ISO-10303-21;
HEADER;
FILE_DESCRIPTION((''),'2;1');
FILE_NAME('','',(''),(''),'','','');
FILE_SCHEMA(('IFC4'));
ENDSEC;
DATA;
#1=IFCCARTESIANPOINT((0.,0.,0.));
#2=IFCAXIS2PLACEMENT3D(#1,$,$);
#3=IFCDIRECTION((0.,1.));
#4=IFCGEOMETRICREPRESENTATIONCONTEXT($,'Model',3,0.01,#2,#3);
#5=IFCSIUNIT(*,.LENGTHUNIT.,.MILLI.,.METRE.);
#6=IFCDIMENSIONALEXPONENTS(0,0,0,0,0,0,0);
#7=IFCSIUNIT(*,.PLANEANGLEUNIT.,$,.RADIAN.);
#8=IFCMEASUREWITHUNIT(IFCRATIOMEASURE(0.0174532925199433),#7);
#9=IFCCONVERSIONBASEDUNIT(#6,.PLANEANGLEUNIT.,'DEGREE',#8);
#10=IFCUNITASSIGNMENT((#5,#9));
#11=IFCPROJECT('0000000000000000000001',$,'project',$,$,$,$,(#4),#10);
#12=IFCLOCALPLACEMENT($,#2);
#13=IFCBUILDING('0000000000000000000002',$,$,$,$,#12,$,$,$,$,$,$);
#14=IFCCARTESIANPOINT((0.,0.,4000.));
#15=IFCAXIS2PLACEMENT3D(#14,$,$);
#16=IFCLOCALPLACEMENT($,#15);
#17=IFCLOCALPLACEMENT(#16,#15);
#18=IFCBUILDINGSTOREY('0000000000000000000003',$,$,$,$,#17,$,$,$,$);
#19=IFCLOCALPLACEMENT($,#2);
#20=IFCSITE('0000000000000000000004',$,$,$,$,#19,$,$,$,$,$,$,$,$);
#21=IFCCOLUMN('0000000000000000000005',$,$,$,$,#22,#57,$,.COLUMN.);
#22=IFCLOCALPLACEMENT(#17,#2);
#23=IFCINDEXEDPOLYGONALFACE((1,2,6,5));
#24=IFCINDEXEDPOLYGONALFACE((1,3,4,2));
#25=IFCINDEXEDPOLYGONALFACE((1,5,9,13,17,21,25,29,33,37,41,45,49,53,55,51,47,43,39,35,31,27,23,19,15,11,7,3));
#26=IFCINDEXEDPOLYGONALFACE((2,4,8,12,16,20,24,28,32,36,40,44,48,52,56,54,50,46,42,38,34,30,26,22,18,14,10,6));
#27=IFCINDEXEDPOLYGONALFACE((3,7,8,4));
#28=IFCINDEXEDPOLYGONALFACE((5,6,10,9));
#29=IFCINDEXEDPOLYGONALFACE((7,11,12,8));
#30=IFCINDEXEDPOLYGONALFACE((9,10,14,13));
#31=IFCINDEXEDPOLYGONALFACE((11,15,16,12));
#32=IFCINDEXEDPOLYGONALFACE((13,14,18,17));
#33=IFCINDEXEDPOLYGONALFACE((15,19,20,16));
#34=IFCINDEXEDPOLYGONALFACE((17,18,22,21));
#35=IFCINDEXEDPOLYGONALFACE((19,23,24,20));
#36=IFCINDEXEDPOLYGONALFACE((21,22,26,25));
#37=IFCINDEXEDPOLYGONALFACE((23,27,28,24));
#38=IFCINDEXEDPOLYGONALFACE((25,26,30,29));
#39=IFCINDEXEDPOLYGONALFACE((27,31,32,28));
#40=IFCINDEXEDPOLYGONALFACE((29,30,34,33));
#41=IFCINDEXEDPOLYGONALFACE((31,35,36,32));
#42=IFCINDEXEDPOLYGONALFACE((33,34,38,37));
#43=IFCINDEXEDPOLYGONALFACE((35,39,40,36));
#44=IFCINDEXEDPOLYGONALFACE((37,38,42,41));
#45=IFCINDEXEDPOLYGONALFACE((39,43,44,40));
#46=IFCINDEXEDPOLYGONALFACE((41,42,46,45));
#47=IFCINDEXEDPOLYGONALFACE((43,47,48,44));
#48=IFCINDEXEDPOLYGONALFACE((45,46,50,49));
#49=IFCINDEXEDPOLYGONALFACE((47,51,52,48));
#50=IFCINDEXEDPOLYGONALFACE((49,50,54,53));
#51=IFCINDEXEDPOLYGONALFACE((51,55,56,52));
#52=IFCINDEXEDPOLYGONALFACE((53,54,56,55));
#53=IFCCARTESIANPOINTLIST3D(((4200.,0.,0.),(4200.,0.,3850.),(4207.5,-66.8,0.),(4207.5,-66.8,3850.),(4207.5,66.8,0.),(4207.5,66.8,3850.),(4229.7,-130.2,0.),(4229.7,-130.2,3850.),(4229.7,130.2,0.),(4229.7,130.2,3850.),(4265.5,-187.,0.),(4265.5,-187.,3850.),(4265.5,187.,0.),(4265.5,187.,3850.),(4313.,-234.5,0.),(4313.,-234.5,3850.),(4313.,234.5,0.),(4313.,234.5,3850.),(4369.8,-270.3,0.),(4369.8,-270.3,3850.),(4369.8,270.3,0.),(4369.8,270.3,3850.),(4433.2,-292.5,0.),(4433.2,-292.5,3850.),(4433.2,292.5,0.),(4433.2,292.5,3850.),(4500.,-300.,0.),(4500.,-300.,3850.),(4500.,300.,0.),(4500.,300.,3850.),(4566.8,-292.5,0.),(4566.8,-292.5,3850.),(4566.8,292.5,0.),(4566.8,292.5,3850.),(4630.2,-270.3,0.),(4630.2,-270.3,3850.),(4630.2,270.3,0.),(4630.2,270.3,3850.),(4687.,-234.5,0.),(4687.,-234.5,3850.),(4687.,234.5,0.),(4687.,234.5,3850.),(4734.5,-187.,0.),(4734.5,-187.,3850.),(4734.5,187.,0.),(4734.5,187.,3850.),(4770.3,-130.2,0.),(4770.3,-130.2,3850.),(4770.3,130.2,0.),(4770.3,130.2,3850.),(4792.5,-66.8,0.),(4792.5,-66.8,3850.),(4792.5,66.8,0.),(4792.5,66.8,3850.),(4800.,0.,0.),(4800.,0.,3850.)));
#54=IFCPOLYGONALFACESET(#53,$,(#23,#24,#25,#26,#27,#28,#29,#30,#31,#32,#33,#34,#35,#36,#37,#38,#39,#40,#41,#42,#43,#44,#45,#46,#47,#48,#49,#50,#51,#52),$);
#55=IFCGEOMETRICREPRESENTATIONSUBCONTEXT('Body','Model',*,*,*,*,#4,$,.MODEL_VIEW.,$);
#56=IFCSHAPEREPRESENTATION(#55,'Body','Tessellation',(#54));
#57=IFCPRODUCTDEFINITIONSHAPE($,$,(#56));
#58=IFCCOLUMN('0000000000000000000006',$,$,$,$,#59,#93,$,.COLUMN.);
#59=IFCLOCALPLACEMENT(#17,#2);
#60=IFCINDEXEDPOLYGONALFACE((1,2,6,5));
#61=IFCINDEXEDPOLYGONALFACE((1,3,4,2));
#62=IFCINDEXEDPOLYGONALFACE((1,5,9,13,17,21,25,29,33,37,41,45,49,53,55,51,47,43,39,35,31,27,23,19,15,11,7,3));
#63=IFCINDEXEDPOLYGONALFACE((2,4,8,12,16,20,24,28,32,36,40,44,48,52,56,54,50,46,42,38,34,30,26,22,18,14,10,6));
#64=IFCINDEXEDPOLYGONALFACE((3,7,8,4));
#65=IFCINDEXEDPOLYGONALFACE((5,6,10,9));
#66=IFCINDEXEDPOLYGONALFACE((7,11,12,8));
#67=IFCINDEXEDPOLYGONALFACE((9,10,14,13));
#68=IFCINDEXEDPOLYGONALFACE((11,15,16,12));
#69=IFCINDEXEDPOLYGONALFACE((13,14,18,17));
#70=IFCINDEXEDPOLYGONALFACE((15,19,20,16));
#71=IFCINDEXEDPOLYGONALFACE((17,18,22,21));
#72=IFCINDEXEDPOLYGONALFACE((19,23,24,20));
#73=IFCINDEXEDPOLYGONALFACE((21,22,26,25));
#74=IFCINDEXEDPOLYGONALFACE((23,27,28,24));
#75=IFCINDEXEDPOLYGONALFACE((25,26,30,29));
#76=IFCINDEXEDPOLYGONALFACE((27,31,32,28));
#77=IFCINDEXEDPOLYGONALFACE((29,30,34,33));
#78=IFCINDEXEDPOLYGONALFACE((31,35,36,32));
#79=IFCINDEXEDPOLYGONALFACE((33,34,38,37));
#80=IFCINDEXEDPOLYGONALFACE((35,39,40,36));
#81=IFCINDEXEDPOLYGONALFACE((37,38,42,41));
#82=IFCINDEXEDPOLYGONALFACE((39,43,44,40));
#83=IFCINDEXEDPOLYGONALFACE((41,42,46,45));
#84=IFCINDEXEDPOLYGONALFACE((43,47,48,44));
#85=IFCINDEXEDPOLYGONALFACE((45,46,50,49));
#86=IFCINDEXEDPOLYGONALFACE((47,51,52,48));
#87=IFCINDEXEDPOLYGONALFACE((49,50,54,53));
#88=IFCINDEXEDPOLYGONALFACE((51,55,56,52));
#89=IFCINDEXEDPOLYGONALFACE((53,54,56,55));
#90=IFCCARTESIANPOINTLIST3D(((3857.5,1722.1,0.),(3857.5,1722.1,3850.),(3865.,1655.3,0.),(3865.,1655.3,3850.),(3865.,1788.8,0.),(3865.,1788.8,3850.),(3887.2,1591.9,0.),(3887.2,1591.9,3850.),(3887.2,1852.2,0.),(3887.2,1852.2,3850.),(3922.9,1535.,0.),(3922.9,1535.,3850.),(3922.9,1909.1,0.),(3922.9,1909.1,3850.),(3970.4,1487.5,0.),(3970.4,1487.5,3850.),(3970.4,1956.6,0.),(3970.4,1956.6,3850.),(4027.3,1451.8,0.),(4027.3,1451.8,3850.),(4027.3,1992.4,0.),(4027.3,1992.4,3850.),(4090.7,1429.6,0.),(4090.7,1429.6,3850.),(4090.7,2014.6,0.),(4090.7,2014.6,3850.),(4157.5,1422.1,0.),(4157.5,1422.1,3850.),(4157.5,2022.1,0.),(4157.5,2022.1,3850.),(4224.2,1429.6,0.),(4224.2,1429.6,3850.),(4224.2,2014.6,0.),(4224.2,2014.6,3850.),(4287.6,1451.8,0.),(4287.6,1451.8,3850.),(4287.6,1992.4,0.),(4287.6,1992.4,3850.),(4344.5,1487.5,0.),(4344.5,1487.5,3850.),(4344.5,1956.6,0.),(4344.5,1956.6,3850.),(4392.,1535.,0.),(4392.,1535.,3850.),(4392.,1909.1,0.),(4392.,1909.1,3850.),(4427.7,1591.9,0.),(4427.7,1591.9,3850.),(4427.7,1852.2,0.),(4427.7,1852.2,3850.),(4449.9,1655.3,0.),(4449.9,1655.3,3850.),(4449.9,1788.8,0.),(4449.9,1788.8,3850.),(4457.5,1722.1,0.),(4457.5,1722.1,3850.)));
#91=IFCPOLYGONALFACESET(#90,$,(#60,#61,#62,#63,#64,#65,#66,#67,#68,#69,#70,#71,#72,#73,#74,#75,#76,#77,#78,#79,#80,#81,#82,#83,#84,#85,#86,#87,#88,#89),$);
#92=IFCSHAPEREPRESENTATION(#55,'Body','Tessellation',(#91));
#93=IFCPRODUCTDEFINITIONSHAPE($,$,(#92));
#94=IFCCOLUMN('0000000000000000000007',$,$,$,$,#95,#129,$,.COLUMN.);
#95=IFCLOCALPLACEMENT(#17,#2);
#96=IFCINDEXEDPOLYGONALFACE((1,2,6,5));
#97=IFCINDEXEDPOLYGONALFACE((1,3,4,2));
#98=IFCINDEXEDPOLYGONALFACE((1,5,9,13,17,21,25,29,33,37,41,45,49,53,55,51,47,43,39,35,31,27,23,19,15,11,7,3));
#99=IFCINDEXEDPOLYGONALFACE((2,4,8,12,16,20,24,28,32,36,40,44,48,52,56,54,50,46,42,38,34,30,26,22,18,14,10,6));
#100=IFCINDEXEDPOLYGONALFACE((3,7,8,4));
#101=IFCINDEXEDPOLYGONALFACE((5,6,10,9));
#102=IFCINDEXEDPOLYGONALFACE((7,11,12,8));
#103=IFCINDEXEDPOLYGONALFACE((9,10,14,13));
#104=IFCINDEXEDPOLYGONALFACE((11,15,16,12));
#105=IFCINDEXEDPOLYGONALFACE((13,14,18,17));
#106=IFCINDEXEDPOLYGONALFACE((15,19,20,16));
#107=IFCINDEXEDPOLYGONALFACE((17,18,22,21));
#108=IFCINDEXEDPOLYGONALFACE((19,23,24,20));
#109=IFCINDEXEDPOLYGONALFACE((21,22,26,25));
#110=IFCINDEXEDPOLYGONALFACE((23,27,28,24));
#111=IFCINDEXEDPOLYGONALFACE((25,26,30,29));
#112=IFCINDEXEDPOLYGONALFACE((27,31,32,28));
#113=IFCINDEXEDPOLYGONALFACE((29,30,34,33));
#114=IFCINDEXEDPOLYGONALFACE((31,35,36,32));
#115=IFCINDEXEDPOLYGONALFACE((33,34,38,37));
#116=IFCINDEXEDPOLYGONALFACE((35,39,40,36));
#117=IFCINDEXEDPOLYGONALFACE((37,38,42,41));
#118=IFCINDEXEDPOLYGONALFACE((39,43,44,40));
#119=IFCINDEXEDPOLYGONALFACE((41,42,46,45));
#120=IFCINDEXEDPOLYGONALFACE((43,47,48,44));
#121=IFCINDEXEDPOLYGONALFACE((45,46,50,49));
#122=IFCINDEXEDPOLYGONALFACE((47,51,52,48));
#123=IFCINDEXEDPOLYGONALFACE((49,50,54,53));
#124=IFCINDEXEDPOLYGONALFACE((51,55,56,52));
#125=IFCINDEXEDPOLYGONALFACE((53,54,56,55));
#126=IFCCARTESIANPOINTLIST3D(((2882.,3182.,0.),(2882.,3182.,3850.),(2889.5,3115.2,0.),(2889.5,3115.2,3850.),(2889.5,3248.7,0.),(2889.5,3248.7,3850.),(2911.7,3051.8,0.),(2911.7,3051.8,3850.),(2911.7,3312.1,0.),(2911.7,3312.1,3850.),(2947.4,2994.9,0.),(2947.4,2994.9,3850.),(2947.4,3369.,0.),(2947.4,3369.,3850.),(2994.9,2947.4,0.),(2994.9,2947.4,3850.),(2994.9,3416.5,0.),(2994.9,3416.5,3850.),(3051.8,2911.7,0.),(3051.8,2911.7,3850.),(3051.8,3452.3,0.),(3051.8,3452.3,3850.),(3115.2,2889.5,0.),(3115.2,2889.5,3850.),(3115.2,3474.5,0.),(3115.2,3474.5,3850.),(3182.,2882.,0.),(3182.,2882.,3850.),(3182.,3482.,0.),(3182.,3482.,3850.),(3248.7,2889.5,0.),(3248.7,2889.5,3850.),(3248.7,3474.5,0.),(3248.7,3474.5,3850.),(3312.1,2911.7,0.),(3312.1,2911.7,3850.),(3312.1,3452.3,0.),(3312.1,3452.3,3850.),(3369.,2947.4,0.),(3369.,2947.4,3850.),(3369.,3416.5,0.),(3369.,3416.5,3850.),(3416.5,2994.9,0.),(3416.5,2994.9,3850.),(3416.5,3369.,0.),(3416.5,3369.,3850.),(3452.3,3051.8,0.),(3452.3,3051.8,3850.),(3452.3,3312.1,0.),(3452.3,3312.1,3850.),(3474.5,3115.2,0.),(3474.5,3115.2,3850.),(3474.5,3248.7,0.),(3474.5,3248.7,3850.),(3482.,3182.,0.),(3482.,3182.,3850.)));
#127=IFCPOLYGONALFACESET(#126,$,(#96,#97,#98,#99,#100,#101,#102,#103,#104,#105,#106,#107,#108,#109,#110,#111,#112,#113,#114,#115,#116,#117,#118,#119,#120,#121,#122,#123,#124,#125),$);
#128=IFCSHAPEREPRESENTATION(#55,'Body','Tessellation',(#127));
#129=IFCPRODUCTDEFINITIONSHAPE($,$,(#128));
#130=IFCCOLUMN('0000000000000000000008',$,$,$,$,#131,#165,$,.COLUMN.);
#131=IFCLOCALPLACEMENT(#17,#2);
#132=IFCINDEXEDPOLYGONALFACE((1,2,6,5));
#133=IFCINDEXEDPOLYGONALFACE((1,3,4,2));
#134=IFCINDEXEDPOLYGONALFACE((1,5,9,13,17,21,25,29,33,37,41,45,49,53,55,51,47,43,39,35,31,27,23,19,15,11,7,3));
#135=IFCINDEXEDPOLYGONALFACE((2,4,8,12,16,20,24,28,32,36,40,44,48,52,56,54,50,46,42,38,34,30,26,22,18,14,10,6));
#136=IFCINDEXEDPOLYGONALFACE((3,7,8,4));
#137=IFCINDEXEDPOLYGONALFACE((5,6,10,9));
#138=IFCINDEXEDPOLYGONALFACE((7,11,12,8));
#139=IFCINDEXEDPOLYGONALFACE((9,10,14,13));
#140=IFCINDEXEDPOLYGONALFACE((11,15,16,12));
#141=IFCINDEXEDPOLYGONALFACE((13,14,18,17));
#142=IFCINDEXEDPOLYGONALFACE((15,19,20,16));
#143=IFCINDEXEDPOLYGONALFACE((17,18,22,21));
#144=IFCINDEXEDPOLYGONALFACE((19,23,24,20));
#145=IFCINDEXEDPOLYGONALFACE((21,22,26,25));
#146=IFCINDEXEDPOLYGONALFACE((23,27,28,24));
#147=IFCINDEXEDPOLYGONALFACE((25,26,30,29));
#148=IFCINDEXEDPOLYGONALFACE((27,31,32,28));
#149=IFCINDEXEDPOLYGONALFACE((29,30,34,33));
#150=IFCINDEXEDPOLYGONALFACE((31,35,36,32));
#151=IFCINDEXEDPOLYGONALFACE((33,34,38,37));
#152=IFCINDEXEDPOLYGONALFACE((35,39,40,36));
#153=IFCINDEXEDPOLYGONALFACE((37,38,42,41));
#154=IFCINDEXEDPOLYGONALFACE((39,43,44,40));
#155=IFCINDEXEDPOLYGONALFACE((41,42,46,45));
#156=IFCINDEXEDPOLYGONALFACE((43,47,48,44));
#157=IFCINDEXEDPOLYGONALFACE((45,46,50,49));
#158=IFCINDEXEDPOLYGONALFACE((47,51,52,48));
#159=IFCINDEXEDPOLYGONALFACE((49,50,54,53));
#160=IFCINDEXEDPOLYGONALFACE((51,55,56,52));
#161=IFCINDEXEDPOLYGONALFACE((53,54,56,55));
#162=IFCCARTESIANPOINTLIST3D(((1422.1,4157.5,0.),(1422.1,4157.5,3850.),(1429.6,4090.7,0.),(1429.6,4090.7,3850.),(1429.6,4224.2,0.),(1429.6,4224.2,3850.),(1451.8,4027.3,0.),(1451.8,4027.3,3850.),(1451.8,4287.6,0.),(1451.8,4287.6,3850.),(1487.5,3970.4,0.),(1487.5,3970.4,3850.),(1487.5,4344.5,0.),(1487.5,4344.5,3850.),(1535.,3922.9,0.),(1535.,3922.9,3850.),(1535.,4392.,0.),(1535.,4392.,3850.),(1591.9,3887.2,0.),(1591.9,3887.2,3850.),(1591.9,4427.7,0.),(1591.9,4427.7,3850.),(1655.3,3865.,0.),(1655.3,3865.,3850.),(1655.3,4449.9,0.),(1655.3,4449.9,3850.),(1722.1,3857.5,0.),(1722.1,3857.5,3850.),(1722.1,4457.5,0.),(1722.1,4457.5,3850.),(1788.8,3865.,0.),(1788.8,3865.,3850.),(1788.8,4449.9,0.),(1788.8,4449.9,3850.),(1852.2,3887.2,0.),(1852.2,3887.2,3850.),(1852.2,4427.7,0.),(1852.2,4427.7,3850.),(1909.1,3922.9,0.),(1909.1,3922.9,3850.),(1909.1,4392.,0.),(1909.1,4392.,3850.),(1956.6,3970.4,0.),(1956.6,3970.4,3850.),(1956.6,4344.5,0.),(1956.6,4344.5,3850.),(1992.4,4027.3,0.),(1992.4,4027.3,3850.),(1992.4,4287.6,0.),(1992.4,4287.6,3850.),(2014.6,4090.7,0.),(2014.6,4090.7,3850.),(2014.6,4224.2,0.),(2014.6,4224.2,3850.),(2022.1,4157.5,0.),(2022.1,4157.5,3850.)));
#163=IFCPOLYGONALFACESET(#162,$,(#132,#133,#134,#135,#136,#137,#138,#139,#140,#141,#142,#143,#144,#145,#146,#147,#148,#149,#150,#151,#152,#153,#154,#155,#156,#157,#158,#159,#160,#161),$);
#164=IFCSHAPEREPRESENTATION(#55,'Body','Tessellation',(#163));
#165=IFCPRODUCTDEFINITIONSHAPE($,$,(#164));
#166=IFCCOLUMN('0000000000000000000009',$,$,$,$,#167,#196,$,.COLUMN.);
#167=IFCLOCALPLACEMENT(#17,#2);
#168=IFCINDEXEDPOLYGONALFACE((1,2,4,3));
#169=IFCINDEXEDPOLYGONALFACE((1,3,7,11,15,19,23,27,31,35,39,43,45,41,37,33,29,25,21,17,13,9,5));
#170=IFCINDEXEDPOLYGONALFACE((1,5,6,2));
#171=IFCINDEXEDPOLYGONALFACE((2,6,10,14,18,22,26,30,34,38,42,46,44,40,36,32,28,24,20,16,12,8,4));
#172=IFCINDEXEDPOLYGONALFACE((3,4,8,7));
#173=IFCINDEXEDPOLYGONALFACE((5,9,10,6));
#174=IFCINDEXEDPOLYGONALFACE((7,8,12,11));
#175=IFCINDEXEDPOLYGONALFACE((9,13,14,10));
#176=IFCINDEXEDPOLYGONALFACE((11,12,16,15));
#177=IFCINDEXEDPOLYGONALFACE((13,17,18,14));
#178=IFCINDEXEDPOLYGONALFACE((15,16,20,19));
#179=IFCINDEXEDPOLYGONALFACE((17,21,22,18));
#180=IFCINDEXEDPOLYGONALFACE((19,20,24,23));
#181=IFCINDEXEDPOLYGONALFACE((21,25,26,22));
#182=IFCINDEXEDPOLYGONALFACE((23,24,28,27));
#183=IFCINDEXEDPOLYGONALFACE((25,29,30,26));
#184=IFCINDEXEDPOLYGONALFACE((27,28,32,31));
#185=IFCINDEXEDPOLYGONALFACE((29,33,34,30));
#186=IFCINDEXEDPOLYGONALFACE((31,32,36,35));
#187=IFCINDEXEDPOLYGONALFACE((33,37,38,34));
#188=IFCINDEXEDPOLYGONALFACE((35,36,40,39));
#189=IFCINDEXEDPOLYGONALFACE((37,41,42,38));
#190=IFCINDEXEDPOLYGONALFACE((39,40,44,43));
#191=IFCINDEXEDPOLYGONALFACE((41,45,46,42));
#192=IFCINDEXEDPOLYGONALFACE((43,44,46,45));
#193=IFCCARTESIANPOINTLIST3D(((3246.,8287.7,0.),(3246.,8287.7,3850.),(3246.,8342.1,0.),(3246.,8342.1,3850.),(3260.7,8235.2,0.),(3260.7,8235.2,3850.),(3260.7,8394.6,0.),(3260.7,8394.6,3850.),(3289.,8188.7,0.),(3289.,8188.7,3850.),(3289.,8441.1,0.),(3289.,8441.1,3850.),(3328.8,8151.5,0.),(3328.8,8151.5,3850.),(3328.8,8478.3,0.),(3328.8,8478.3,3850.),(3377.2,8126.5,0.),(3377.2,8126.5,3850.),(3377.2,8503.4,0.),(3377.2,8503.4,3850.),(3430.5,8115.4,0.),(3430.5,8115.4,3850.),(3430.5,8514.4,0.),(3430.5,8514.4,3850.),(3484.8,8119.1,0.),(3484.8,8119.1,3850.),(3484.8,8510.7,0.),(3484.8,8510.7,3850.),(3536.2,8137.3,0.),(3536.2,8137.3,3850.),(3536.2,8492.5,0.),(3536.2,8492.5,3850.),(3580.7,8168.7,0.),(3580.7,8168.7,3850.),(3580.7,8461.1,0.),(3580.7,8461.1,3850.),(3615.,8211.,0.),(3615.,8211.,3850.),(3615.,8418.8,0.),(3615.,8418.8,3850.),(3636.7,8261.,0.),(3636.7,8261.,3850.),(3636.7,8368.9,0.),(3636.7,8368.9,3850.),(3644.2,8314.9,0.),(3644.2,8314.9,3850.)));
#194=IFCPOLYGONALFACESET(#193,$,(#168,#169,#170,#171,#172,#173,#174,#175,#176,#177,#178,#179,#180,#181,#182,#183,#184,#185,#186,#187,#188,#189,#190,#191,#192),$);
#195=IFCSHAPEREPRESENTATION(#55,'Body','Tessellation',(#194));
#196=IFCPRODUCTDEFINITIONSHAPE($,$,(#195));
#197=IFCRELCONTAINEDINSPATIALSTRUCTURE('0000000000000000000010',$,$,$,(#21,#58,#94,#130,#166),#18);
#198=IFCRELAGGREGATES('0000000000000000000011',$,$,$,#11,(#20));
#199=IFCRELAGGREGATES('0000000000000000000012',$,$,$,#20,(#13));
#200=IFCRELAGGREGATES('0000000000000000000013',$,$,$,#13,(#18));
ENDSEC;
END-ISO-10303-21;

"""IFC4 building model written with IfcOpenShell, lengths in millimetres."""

from ifc_helpers import new_model, entity, si_unit, converted_unit, direction, frame, origin, origin_2d, place, context, subcontext, project, spatial, circle, extrude, element, save


model = new_model("IFC4")

# Units and contexts
model_context = context("Model", 3, precision=0.01, world=origin(), true_north=direction((0.0, 1.0)))
body_context = subcontext(model_context, "Body", "Model", "MODEL_VIEW")
ifc_project = project(units=[si_unit("LENGTHUNIT", "METRE", prefix="MILLI"), converted_unit("PLANEANGLEUNIT", "DEGREE", entity("IfcRatioMeasure", 0.0174532925199433), si_unit("PLANEANGLEUNIT", "RADIAN"), dimensions=[0, 0, 0, 0, 0, 0, 0])], contexts=[model_context])

# Site, building, storey
site_placement = place(None, origin())
site = spatial("IfcSite", under=ifc_project, at=site_placement)
building_placement = place(None, origin())
building = spatial("IfcBuilding", under=site, at=building_placement)
placement = place(None, frame((0.0, 0.0, 4000.0)))
storey_placement = place(placement, frame((0.0, 0.0, 4000.0)))
storey = spatial("IfcBuildingStorey", under=building, at=storey_placement)

# Columns
for number, where in (
    (1, (4500.0, 0.0, 0.0)),
    (2, (4157.5, 1722.1, 0.0)),
    (3, (3182.0, 3182.0, 0.0)),
    (4, (1722.1, 4157.5, 0.0)),
):
    element("IfcColumn", number, at=place(storey_placement, frame(where)), inside=storey, PredefinedType="COLUMN", context=body_context, shape_type="SweptSolid", body=[
        extrude(circle(Radius=300.0, at=origin_2d()), origin(), (0.0, 0.0, 1.0), 3850.0),
    ])
column_placement = place(storey_placement, frame((3444.2, 8314.9, 0.0)))
element("IfcColumn", 5, at=column_placement, inside=storey, PredefinedType="COLUMN", context=body_context, shape_type="SweptSolid", body=[
    extrude(circle(Radius=200.0, at=origin_2d()), origin(), (0.0, 0.0, 1.0), 3850.0),
])

save(model, "model.ifc")
